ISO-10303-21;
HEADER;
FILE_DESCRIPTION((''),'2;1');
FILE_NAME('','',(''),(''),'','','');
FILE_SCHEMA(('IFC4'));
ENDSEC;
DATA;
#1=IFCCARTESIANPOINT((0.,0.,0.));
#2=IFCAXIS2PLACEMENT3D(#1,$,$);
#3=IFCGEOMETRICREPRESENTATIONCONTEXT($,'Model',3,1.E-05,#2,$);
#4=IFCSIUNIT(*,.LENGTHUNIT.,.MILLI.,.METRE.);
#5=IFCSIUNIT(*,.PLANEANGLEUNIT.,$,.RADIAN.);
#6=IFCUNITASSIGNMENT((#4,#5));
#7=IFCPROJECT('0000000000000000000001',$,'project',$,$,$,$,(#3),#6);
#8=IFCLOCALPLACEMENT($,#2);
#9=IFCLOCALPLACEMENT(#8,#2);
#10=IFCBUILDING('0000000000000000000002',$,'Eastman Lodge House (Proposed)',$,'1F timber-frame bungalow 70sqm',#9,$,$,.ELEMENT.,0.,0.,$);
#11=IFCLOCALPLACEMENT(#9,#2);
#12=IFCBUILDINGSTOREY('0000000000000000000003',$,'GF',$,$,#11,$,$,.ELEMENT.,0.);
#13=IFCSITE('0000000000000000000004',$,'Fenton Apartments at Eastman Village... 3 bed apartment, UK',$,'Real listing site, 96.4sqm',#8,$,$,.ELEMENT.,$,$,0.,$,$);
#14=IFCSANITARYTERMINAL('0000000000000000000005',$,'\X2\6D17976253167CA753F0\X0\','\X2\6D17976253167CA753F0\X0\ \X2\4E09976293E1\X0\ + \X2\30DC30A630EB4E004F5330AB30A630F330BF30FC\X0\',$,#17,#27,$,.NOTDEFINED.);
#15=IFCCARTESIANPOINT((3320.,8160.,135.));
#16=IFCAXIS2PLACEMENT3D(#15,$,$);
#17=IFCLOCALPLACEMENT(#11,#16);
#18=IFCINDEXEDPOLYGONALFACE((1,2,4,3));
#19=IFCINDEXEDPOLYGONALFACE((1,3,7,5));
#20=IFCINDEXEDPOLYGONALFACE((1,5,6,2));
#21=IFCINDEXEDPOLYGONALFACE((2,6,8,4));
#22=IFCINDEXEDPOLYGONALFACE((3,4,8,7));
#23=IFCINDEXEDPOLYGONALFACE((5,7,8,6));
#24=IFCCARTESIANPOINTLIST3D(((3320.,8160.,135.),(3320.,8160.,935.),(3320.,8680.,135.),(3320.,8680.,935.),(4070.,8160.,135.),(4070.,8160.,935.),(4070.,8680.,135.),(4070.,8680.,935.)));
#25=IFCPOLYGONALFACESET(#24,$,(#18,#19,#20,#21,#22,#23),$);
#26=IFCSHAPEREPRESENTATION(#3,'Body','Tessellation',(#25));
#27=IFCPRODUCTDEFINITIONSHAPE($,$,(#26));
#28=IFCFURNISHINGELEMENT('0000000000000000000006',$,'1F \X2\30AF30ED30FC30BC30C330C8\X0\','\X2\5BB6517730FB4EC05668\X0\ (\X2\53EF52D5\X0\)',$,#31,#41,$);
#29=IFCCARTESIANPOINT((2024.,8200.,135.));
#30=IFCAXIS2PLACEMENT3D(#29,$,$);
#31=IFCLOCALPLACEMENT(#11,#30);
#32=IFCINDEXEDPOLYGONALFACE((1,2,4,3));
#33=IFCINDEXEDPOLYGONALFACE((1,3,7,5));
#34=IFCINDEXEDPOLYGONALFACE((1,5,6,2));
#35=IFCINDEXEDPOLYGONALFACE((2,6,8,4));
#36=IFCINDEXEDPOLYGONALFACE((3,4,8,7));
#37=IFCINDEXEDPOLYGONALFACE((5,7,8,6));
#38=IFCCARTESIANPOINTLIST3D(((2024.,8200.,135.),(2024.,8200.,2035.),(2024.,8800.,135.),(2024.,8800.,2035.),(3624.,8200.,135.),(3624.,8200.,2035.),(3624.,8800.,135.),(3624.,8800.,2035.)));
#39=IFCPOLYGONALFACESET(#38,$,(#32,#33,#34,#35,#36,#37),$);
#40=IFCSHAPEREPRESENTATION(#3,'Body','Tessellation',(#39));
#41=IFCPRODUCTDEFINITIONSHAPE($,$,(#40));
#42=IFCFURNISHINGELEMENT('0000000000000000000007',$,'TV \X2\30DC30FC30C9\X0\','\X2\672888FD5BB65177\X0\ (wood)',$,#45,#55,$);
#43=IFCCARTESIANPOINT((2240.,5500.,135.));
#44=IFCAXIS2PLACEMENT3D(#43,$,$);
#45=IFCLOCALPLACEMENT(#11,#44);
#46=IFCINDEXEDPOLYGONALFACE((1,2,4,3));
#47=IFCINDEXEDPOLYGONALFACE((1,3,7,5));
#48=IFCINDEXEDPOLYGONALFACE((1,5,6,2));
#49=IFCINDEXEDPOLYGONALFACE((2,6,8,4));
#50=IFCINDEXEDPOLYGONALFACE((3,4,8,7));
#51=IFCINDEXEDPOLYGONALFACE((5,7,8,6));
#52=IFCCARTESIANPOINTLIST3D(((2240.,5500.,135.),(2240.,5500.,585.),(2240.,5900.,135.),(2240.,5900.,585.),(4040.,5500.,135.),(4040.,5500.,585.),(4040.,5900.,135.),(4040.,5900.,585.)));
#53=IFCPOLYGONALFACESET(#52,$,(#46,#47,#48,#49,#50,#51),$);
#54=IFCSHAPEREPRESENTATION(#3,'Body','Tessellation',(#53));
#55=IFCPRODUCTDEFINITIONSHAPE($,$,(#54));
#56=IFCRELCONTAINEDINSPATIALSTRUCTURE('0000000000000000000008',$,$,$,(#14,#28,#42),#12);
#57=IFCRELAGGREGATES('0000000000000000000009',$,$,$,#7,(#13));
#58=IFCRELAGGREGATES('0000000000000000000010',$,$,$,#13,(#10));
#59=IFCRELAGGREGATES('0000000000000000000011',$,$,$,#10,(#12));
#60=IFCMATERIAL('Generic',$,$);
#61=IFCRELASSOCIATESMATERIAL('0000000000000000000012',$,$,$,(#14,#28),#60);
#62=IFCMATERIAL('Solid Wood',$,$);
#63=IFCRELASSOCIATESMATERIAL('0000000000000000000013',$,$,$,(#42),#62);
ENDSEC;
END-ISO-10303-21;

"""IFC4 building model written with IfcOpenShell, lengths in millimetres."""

from ifc_helpers import new_model, si_unit, frame, frame_2d, origin, place, context, project, spatial, rectangle, extrude, material, element, save


model = new_model("IFC4")

# Units and contexts
model_context = context("Model", 3, precision=1e-05, world=origin())
ifc_project = project(units=[si_unit("LENGTHUNIT", "METRE", prefix="MILLI"), si_unit("PLANEANGLEUNIT", "RADIAN")], contexts=[model_context])

# Site, building, storey
site_placement = place(None, origin())
site = spatial("IfcSite", under=ifc_project, at=site_placement, Name="Fenton Apartments at Eastman Village... 3 bed apartment, UK", ObjectType="Real listing site, 96.4sqm", CompositionType="ELEMENT", RefElevation=0.0)
building_placement = place(site_placement, origin())
building = spatial("IfcBuilding", under=site, at=building_placement, Name="Eastman Lodge House (Proposed)", ObjectType="1F timber-frame bungalow 70sqm", CompositionType="ELEMENT", ElevationOfRefHeight=0.0, ElevationOfTerrain=0.0)
storey_placement = place(building_placement, origin())
storey = spatial("IfcBuildingStorey", under=building, at=storey_placement, Name="GF", CompositionType="ELEMENT", Elevation=0.0)

# Shared definitions
ifc_material_1 = material(Name="Solid Wood")

# Shared definitions
ifc_material_2 = material(Name="Generic")

# Sanitary terminal
sanitary_terminal_1_placement = place(storey_placement, frame((3320.0, 8160.0, 135.0)))
element("IfcSanitaryTerminal", 1, at=sanitary_terminal_1_placement, inside=storey, material=ifc_material_2, Name="洗面化粧台", Description="洗面化粧台 三面鏡 + ボウル一体カウンター", PredefinedType="NOTDEFINED", context=model_context, shape_type="SweptSolid", body=[
    extrude(rectangle(XDim=750.0, YDim=520.0, at=frame_2d((375.0, 260.0))), frame((3320.0, 8160.0, 135.0)), (0.0, 0.0, 1.0), 800.0),
])

# Furnishing elements
furnishing_1_placement = place(storey_placement, frame((2024.0, 8200.0, 135.0)))
element("IfcFurnishingElement", 2, at=furnishing_1_placement, inside=storey, material=ifc_material_2, Name="1F クローゼット", Description="家具・什器 (可動)", context=model_context, shape_type="SweptSolid", body=[
    extrude(rectangle(XDim=1600.0, YDim=600.0, at=frame_2d((800.0, 300.0))), frame((2024.0, 8200.0, 135.0)), (0.0, 0.0, 1.0), 1900.0),
])
furnishing_2_placement = place(storey_placement, frame((2240.0, 5500.0, 135.0)))
element("IfcFurnishingElement", 3, at=furnishing_2_placement, inside=storey, material=ifc_material_1, Name="TV ボード", Description="木製家具 (wood)", context=model_context, shape_type="SweptSolid", body=[
    extrude(rectangle(XDim=1800.0, YDim=400.0, at=frame_2d((900.0, 200.0))), frame((2240.0, 5500.0, 135.0)), (0.0, 0.0, 1.0), 450.0),
])

save(model, "model.ifc")
